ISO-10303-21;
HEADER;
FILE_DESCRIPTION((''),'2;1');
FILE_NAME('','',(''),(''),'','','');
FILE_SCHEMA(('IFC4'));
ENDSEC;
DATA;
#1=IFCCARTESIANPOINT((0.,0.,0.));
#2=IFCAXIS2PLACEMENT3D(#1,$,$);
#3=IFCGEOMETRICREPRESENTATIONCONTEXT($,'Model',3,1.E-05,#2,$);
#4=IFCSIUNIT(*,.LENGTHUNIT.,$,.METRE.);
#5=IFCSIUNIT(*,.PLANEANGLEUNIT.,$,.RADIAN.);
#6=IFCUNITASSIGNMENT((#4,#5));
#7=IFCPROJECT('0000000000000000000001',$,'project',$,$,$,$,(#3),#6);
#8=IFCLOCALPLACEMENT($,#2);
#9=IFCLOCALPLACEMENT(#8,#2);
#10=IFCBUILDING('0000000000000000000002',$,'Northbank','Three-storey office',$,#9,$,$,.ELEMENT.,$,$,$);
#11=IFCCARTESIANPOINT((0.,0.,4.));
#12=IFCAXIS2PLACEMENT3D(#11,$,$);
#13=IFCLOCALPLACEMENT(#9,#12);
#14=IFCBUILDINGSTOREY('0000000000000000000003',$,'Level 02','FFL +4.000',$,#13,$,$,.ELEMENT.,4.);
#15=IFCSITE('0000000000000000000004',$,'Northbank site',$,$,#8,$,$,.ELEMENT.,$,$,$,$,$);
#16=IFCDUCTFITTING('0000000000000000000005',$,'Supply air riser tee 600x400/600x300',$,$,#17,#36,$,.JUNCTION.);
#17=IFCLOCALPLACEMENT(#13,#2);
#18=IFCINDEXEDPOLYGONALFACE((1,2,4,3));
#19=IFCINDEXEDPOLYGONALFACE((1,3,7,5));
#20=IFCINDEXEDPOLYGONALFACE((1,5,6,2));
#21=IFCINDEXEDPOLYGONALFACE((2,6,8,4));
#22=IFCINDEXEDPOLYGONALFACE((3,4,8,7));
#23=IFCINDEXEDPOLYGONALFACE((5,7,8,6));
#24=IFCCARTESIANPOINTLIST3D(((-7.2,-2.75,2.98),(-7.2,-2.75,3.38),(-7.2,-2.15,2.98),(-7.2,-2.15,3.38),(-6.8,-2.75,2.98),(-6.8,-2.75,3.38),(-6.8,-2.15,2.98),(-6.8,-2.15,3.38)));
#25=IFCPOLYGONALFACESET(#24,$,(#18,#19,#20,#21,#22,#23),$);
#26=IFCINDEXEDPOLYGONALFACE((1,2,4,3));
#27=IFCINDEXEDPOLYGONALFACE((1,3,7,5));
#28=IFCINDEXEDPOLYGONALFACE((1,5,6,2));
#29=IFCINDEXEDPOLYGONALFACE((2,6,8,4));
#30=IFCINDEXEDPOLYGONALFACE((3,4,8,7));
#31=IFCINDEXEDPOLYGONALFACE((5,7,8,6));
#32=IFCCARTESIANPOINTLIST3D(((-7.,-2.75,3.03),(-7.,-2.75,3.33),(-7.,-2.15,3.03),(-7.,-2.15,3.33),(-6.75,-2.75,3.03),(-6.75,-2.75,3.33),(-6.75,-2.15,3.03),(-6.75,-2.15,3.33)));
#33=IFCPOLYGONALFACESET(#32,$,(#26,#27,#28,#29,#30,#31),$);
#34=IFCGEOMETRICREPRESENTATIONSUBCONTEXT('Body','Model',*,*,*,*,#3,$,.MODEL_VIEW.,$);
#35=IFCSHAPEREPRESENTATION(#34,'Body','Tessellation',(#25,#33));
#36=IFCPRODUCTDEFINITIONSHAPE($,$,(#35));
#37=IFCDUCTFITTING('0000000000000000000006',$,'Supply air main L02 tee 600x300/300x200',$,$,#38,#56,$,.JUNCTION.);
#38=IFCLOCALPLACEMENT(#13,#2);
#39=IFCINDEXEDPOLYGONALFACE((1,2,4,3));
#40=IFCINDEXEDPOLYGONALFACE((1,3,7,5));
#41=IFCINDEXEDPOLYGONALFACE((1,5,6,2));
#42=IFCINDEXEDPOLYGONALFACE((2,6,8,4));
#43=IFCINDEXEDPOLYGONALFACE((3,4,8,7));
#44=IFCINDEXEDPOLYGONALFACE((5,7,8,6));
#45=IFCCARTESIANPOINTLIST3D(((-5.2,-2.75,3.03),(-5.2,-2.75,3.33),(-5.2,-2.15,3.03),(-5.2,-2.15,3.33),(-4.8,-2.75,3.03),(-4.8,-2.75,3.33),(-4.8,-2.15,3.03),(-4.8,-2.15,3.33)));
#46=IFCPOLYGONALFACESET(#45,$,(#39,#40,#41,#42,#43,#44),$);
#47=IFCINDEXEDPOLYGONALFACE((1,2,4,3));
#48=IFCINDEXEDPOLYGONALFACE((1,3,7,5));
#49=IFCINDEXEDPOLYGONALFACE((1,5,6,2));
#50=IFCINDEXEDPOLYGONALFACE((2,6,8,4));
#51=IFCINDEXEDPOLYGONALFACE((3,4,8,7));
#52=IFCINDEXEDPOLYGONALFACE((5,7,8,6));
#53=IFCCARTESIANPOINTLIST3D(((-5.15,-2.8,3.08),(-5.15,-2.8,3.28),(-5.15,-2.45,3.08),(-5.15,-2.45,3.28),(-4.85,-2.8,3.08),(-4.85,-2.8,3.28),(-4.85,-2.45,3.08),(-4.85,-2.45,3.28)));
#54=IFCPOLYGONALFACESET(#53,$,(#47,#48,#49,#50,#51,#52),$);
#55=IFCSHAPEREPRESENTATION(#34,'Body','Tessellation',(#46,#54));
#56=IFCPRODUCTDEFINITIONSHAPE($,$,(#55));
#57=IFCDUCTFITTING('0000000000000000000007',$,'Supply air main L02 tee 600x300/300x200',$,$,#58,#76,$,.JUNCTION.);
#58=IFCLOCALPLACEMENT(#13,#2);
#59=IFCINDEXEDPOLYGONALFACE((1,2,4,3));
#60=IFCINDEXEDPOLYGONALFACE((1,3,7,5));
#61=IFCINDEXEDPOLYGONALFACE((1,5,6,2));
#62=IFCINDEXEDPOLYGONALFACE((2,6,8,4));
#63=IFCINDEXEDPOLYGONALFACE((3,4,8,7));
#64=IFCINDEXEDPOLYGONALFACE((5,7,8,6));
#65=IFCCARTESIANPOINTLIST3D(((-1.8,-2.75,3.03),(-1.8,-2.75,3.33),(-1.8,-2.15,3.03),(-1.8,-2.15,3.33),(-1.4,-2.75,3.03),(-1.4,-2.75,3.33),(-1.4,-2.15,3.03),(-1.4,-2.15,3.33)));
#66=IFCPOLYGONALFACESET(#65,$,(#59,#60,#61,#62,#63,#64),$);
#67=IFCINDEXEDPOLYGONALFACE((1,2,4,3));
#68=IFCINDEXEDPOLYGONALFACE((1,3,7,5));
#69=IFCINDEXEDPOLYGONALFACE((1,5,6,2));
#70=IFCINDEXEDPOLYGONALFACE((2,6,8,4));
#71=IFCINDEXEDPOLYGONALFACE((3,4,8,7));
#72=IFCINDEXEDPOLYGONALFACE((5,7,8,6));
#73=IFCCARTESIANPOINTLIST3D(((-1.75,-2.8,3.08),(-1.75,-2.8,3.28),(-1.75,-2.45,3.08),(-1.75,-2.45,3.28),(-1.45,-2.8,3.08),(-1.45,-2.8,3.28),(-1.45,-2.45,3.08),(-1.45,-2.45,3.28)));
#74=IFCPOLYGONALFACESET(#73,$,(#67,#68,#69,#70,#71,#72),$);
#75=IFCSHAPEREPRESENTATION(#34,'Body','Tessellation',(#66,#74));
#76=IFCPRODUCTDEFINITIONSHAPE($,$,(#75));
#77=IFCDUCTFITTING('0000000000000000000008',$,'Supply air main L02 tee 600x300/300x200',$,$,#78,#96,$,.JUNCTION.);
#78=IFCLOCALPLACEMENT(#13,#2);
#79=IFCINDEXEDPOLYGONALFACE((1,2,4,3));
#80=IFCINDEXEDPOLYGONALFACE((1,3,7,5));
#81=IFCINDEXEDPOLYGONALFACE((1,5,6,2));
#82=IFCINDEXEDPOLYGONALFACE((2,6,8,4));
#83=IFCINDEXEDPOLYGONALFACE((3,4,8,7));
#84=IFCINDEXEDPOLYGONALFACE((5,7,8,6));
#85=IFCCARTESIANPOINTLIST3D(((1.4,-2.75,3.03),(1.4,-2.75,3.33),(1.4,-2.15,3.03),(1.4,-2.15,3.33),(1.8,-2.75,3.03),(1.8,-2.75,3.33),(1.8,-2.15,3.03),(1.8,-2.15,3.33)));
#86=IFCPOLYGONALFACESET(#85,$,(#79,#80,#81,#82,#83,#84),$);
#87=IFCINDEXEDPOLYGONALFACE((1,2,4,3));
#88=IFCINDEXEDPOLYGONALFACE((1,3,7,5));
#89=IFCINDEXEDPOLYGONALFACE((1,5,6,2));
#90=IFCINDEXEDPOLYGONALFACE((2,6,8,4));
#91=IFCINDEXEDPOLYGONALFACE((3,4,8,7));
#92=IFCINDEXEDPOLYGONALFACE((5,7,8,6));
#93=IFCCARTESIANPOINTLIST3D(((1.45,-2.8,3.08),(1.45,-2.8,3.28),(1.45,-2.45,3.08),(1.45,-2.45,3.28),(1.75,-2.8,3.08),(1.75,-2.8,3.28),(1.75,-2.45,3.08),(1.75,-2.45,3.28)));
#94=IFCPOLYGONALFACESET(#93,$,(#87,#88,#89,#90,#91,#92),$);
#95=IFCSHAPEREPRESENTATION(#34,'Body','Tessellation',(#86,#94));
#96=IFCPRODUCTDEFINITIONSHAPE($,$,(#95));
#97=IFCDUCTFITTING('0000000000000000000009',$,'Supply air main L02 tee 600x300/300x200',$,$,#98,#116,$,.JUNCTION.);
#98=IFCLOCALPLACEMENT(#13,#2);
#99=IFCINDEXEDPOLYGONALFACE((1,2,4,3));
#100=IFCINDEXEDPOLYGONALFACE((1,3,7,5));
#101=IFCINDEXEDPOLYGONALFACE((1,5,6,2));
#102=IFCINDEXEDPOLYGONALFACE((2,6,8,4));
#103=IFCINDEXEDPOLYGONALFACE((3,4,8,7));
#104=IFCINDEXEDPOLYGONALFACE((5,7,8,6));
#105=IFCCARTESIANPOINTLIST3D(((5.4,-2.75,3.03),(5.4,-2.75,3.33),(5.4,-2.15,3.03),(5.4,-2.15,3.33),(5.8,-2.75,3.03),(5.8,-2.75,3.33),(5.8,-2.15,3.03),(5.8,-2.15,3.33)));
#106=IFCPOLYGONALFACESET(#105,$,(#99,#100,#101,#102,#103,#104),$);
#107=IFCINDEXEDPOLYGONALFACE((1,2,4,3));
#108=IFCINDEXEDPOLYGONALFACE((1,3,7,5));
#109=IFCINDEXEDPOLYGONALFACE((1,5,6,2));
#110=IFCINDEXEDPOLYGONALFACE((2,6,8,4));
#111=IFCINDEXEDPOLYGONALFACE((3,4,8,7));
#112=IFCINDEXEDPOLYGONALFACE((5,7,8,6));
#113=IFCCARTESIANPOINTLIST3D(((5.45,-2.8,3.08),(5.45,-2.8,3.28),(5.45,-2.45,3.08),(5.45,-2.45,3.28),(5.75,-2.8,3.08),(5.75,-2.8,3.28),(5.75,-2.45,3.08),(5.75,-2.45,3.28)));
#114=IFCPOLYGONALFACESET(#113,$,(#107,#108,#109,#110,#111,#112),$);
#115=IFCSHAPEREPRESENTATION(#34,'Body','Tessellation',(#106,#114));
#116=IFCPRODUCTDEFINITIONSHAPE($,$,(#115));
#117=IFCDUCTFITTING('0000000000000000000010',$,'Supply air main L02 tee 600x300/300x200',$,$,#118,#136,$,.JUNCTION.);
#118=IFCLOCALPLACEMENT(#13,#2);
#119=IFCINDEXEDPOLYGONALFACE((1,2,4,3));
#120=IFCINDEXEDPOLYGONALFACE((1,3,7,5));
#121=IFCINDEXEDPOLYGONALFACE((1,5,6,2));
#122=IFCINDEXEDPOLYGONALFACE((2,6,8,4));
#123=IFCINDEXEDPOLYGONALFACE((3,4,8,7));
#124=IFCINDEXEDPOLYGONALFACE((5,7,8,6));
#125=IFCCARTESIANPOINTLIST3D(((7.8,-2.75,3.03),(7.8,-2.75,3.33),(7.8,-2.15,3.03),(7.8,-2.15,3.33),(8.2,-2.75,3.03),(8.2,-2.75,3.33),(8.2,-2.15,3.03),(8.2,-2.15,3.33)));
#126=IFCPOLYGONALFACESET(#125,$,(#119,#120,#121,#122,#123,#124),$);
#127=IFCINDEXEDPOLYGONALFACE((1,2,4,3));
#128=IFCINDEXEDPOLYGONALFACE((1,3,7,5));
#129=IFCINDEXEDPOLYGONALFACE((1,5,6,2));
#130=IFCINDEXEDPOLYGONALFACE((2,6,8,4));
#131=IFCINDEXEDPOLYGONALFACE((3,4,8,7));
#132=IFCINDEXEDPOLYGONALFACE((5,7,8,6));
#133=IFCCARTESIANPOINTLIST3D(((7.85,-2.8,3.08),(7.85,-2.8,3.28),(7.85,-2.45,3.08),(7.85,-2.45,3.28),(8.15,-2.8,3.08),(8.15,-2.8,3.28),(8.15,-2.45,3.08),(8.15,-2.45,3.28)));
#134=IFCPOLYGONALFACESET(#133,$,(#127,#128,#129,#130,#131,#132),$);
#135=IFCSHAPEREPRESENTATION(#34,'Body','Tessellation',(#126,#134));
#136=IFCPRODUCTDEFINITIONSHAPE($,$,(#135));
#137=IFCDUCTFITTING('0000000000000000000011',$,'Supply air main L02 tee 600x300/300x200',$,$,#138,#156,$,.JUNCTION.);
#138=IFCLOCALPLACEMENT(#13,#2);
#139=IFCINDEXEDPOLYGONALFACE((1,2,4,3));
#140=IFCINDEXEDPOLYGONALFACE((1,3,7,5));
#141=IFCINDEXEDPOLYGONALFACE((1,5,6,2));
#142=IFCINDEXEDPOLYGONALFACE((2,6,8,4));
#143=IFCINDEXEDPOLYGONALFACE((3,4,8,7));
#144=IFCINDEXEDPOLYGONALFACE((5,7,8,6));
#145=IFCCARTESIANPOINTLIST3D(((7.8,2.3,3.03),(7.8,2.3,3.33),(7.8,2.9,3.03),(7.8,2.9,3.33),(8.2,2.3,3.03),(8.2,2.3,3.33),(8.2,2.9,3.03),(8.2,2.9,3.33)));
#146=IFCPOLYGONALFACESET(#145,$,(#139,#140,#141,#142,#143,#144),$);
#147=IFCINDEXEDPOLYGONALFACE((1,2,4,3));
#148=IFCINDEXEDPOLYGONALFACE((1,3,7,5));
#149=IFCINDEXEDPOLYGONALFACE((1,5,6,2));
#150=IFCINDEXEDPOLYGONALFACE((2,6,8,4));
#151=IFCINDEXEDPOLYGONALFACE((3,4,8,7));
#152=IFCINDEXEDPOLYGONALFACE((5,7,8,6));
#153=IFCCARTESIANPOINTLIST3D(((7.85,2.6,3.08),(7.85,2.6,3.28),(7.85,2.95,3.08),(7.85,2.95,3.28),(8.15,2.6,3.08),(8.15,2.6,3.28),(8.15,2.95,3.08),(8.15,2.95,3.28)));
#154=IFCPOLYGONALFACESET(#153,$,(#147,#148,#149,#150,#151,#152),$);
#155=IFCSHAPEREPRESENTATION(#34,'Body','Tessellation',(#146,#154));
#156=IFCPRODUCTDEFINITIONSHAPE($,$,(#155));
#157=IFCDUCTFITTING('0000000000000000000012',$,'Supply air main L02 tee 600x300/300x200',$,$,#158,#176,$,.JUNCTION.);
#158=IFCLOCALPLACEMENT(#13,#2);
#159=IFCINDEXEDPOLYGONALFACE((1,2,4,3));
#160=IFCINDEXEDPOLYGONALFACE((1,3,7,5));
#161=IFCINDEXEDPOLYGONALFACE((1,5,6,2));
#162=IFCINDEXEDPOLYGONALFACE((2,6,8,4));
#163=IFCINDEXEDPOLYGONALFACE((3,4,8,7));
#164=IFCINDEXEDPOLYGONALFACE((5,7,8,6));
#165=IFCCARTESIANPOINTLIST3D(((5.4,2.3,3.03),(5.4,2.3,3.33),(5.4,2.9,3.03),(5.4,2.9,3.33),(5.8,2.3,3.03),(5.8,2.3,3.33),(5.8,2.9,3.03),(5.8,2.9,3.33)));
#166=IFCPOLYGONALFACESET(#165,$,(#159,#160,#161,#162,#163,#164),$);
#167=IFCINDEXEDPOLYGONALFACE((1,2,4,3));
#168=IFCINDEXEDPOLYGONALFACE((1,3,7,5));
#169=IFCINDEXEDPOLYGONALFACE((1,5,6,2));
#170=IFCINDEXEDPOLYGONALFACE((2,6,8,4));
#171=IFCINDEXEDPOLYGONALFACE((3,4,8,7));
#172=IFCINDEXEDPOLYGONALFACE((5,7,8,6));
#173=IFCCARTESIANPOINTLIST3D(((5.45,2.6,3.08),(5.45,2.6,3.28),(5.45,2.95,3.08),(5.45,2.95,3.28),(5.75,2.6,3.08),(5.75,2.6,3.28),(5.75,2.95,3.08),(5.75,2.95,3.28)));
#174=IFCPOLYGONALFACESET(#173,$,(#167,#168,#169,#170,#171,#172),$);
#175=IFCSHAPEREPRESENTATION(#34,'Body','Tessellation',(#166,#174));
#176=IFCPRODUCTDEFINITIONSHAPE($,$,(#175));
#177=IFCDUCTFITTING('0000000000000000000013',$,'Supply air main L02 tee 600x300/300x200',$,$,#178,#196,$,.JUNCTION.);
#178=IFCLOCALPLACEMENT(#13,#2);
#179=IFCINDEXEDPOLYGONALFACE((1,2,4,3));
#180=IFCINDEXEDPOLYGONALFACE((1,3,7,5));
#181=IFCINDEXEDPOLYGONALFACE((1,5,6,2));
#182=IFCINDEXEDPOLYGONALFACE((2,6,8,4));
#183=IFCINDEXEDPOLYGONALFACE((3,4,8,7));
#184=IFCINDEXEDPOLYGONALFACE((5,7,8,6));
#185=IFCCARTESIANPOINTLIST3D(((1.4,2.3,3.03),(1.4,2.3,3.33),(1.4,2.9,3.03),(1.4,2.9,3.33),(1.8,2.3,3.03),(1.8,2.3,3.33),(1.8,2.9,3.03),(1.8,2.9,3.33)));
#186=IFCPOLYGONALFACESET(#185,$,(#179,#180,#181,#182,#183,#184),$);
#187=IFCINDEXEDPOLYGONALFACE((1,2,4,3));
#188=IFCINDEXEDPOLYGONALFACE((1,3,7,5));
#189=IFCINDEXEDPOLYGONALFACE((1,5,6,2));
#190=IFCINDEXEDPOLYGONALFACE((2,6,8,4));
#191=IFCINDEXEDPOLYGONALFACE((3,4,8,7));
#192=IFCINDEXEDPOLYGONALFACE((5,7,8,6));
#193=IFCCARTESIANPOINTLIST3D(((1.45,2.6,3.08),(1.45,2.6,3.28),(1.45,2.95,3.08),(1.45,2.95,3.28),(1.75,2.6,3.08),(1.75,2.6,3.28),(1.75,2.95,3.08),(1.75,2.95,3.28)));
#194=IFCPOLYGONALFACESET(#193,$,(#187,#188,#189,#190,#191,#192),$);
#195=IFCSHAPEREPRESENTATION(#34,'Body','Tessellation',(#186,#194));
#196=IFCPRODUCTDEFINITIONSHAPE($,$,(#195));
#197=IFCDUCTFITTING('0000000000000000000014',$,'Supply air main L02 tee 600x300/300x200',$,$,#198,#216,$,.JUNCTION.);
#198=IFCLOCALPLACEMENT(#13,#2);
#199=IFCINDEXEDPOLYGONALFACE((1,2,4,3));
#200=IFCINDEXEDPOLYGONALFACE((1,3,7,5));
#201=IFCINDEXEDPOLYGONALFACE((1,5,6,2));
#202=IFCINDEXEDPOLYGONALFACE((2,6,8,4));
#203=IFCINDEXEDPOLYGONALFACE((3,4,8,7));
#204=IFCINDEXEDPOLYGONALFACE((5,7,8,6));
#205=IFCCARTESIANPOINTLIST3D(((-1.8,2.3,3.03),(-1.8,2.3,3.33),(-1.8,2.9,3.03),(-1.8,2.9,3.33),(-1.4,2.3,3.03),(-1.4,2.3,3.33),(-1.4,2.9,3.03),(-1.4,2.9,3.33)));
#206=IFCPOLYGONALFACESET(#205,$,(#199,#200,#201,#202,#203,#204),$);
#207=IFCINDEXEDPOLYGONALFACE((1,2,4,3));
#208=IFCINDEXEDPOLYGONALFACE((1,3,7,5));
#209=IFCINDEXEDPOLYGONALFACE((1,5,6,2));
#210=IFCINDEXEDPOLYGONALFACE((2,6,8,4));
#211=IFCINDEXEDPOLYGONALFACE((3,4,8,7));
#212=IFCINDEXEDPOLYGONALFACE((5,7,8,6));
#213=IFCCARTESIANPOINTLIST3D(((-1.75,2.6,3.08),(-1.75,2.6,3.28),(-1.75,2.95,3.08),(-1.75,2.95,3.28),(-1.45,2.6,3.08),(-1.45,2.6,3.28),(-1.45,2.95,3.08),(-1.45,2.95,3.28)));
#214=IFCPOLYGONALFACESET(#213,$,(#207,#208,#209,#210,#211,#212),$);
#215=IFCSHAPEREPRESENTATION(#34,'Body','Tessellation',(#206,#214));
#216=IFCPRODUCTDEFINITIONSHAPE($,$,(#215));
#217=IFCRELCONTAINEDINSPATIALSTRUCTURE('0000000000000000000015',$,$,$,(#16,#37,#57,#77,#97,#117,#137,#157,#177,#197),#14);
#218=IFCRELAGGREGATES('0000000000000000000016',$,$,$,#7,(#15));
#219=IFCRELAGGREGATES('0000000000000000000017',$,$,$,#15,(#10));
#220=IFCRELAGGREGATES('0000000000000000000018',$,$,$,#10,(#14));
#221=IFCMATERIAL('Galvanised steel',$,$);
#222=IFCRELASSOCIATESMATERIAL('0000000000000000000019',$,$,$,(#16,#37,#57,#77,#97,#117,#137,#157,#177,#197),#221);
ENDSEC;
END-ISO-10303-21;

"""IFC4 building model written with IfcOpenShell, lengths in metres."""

from ifc_helpers import new_model, si_unit, frame, origin, place, context, subcontext, project, spatial, rectangle, extrude, material, element, save


model = new_model("IFC4")

# Units and contexts
model_context = context("Model", 3, precision=1e-05, world=origin())
body_context = subcontext(model_context, "Body", "Model", "MODEL_VIEW")
ifc_project = project(units=[si_unit("LENGTHUNIT", "METRE"), si_unit("PLANEANGLEUNIT", "RADIAN")], contexts=[model_context])

# Site, building, storey
site_placement = place(None, origin())
site = spatial("IfcSite", under=ifc_project, at=site_placement, Name="Northbank site", CompositionType="ELEMENT")
building_placement = place(site_placement, origin())
building = spatial("IfcBuilding", under=site, at=building_placement, Name="Northbank", Description="Three-storey office", CompositionType="ELEMENT")
storey_placement = place(building_placement, frame((0.0, 0.0, 4.0)))
storey = spatial("IfcBuildingStorey", under=building, at=storey_placement, Name="Level 02", Description="FFL +4.000", CompositionType="ELEMENT", Elevation=4.0)

# Duct fitting
ifc_material = material(Name="Galvanised steel")
duct_fitting_1_placement = place(storey_placement, frame((0.0, 0.0, -4.0)))
element("IfcDuctFitting", 1, at=duct_fitting_1_placement, inside=storey, material=ifc_material, Name="Supply air riser tee 600x400/600x300", PredefinedType="JUNCTION", context=body_context, shape_type="SweptSolid", body=[
    extrude(rectangle(XDim=0.6, YDim=0.4), frame((-7.0, -2.45, 7.38), z_axis=(0.0, 0.0, -1.0), x_axis=(0.0, -1.0, 0.0)), (0.0, 0.0, 1.0), 0.4),
    extrude(rectangle(XDim=0.6, YDim=0.3), frame((-7.0, -2.45, 7.18), z_axis=(1.0, 0.0, 0.0), x_axis=(0.0, 1.0, 0.0)), (0.0, 0.0, 1.0), 0.25),
])

# Duct fitting
duct_fitting_2_placement = place(storey_placement, frame((0.0, 0.0, -4.0)))
element("IfcDuctFitting", 2, at=duct_fitting_2_placement, inside=storey, material=ifc_material, Name="Supply air main L02 tee 600x300/300x200", PredefinedType="JUNCTION", context=body_context, shape_type="SweptSolid", body=[
    extrude(rectangle(XDim=0.6, YDim=0.3), frame((-5.2, -2.45, 7.18), z_axis=(1.0, 0.0, 0.0), x_axis=(0.0, 1.0, 0.0)), (0.0, 0.0, 1.0), 0.4),
    extrude(rectangle(XDim=0.3, YDim=0.2), frame((-5.0, -2.45, 7.18), z_axis=(0.0, -1.0, 0.0), x_axis=(1.0, 0.0, 0.0)), (0.0, 0.0, 1.0), 0.35),
])

# Duct fitting
duct_fitting_3_placement = place(storey_placement, frame((0.0, 0.0, -4.0)))
element("IfcDuctFitting", 3, at=duct_fitting_3_placement, inside=storey, material=ifc_material, Name="Supply air main L02 tee 600x300/300x200", PredefinedType="JUNCTION", context=body_context, shape_type="SweptSolid", body=[
    extrude(rectangle(XDim=0.6, YDim=0.3), frame((-1.8, -2.45, 7.18), z_axis=(1.0, 0.0, 0.0), x_axis=(0.0, 1.0, 0.0)), (0.0, 0.0, 1.0), 0.4),
    extrude(rectangle(XDim=0.3, YDim=0.2), frame((-1.6, -2.45, 7.18), z_axis=(0.0, -1.0, 0.0), x_axis=(1.0, 0.0, 0.0)), (0.0, 0.0, 1.0), 0.35),
])

# Duct fitting
duct_fitting_4_placement = place(storey_placement, frame((0.0, 0.0, -4.0)))
element("IfcDuctFitting", 4, at=duct_fitting_4_placement, inside=storey, material=ifc_material, Name="Supply air main L02 tee 600x300/300x200", PredefinedType="JUNCTION", context=body_context, shape_type="SweptSolid", body=[
    extrude(rectangle(XDim=0.6, YDim=0.3), frame((1.4, -2.45, 7.18), z_axis=(1.0, 0.0, 0.0), x_axis=(0.0, 1.0, 0.0)), (0.0, 0.0, 1.0), 0.4),
    extrude(rectangle(XDim=0.3, YDim=0.2), frame((1.6, -2.45, 7.18), z_axis=(0.0, -1.0, 0.0), x_axis=(1.0, 0.0, 0.0)), (0.0, 0.0, 1.0), 0.35),
])

# Duct fitting
duct_fitting_5_placement = place(storey_placement, frame((0.0, 0.0, -4.0)))
element("IfcDuctFitting", 5, at=duct_fitting_5_placement, inside=storey, material=ifc_material, Name="Supply air main L02 tee 600x300/300x200", PredefinedType="JUNCTION", context=body_context, shape_type="SweptSolid", body=[
    extrude(rectangle(XDim=0.6, YDim=0.3), frame((5.4, -2.45, 7.18), z_axis=(1.0, 0.0, 0.0), x_axis=(0.0, 1.0, 0.0)), (0.0, 0.0, 1.0), 0.4),
    extrude(rectangle(XDim=0.3, YDim=0.2), frame((5.6, -2.45, 7.18), z_axis=(0.0, -1.0, 0.0), x_axis=(1.0, 0.0, 0.0)), (0.0, 0.0, 1.0), 0.35),
])

# Duct fitting
duct_fitting_6_placement = place(storey_placement, frame((0.0, 0.0, -4.0)))
element("IfcDuctFitting", 6, at=duct_fitting_6_placement, inside=storey, material=ifc_material, Name="Supply air main L02 tee 600x300/300x200", PredefinedType="JUNCTION", context=body_context, shape_type="SweptSolid", body=[
    extrude(rectangle(XDim=0.6, YDim=0.3), frame((7.8, -2.45, 7.18), z_axis=(1.0, 0.0, 0.0), x_axis=(0.0, 1.0, 0.0)), (0.0, 0.0, 1.0), 0.4),
    extrude(rectangle(XDim=0.3, YDim=0.2), frame((8.0, -2.45, 7.18), z_axis=(0.0, -1.0, 0.0), x_axis=(1.0, 0.0, 0.0)), (0.0, 0.0, 1.0), 0.35),
])

# Duct fitting
duct_fitting_7_placement = place(storey_placement, frame((0.0, 0.0, -4.0)))
element("IfcDuctFitting", 7, at=duct_fitting_7_placement, inside=storey, material=ifc_material, Name="Supply air main L02 tee 600x300/300x200", PredefinedType="JUNCTION", context=body_context, shape_type="SweptSolid", body=[
    extrude(rectangle(XDim=0.6, YDim=0.3), frame((8.2, 2.6, 7.18), z_axis=(-1.0, 0.0, 0.0), x_axis=(0.0, -1.0, 0.0)), (0.0, 0.0, 1.0), 0.4),
    extrude(rectangle(XDim=0.3, YDim=0.2), frame((8.0, 2.6, 7.18), z_axis=(0.0, 1.0, 0.0), x_axis=(-1.0, 0.0, 0.0)), (0.0, 0.0, 1.0), 0.35),
])

# Duct fitting
duct_fitting_8_placement = place(storey_placement, frame((0.0, 0.0, -4.0)))
element("IfcDuctFitting", 8, at=duct_fitting_8_placement, inside=storey, material=ifc_material, Name="Supply air main L02 tee 600x300/300x200", PredefinedType="JUNCTION", context=body_context, shape_type="SweptSolid", body=[
    extrude(rectangle(XDim=0.6, YDim=0.3), frame((5.8, 2.6, 7.18), z_axis=(-1.0, 0.0, 0.0), x_axis=(0.0, -1.0, 0.0)), (0.0, 0.0, 1.0), 0.4),
    extrude(rectangle(XDim=0.3, YDim=0.2), frame((5.6, 2.6, 7.18), z_axis=(0.0, 1.0, 0.0), x_axis=(-1.0, 0.0, 0.0)), (0.0, 0.0, 1.0), 0.35),
])

# Duct fitting
duct_fitting_9_placement = place(storey_placement, frame((0.0, 0.0, -4.0)))
element("IfcDuctFitting", 9, at=duct_fitting_9_placement, inside=storey, material=ifc_material, Name="Supply air main L02 tee 600x300/300x200", PredefinedType="JUNCTION", context=body_context, shape_type="SweptSolid", body=[
    extrude(rectangle(XDim=0.6, YDim=0.3), frame((1.8, 2.6, 7.18), z_axis=(-1.0, 0.0, 0.0), x_axis=(0.0, -1.0, 0.0)), (0.0, 0.0, 1.0), 0.4),
    extrude(rectangle(XDim=0.3, YDim=0.2), frame((1.6, 2.6, 7.18), z_axis=(0.0, 1.0, 0.0), x_axis=(-1.0, 0.0, 0.0)), (0.0, 0.0, 1.0), 0.35),
])

# Duct fitting
duct_fitting_10_placement = place(storey_placement, frame((0.0, 0.0, -4.0)))
element("IfcDuctFitting", 10, at=duct_fitting_10_placement, inside=storey, material=ifc_material, Name="Supply air main L02 tee 600x300/300x200", PredefinedType="JUNCTION", context=body_context, shape_type="SweptSolid", body=[
    extrude(rectangle(XDim=0.6, YDim=0.3), frame((-1.4, 2.6, 7.18), z_axis=(-1.0, 0.0, 0.0), x_axis=(0.0, -1.0, 0.0)), (0.0, 0.0, 1.0), 0.4),
    extrude(rectangle(XDim=0.3, YDim=0.2), frame((-1.6, 2.6, 7.18), z_axis=(0.0, 1.0, 0.0), x_axis=(-1.0, 0.0, 0.0)), (0.0, 0.0, 1.0), 0.35),
])

save(model, "model.ifc")
